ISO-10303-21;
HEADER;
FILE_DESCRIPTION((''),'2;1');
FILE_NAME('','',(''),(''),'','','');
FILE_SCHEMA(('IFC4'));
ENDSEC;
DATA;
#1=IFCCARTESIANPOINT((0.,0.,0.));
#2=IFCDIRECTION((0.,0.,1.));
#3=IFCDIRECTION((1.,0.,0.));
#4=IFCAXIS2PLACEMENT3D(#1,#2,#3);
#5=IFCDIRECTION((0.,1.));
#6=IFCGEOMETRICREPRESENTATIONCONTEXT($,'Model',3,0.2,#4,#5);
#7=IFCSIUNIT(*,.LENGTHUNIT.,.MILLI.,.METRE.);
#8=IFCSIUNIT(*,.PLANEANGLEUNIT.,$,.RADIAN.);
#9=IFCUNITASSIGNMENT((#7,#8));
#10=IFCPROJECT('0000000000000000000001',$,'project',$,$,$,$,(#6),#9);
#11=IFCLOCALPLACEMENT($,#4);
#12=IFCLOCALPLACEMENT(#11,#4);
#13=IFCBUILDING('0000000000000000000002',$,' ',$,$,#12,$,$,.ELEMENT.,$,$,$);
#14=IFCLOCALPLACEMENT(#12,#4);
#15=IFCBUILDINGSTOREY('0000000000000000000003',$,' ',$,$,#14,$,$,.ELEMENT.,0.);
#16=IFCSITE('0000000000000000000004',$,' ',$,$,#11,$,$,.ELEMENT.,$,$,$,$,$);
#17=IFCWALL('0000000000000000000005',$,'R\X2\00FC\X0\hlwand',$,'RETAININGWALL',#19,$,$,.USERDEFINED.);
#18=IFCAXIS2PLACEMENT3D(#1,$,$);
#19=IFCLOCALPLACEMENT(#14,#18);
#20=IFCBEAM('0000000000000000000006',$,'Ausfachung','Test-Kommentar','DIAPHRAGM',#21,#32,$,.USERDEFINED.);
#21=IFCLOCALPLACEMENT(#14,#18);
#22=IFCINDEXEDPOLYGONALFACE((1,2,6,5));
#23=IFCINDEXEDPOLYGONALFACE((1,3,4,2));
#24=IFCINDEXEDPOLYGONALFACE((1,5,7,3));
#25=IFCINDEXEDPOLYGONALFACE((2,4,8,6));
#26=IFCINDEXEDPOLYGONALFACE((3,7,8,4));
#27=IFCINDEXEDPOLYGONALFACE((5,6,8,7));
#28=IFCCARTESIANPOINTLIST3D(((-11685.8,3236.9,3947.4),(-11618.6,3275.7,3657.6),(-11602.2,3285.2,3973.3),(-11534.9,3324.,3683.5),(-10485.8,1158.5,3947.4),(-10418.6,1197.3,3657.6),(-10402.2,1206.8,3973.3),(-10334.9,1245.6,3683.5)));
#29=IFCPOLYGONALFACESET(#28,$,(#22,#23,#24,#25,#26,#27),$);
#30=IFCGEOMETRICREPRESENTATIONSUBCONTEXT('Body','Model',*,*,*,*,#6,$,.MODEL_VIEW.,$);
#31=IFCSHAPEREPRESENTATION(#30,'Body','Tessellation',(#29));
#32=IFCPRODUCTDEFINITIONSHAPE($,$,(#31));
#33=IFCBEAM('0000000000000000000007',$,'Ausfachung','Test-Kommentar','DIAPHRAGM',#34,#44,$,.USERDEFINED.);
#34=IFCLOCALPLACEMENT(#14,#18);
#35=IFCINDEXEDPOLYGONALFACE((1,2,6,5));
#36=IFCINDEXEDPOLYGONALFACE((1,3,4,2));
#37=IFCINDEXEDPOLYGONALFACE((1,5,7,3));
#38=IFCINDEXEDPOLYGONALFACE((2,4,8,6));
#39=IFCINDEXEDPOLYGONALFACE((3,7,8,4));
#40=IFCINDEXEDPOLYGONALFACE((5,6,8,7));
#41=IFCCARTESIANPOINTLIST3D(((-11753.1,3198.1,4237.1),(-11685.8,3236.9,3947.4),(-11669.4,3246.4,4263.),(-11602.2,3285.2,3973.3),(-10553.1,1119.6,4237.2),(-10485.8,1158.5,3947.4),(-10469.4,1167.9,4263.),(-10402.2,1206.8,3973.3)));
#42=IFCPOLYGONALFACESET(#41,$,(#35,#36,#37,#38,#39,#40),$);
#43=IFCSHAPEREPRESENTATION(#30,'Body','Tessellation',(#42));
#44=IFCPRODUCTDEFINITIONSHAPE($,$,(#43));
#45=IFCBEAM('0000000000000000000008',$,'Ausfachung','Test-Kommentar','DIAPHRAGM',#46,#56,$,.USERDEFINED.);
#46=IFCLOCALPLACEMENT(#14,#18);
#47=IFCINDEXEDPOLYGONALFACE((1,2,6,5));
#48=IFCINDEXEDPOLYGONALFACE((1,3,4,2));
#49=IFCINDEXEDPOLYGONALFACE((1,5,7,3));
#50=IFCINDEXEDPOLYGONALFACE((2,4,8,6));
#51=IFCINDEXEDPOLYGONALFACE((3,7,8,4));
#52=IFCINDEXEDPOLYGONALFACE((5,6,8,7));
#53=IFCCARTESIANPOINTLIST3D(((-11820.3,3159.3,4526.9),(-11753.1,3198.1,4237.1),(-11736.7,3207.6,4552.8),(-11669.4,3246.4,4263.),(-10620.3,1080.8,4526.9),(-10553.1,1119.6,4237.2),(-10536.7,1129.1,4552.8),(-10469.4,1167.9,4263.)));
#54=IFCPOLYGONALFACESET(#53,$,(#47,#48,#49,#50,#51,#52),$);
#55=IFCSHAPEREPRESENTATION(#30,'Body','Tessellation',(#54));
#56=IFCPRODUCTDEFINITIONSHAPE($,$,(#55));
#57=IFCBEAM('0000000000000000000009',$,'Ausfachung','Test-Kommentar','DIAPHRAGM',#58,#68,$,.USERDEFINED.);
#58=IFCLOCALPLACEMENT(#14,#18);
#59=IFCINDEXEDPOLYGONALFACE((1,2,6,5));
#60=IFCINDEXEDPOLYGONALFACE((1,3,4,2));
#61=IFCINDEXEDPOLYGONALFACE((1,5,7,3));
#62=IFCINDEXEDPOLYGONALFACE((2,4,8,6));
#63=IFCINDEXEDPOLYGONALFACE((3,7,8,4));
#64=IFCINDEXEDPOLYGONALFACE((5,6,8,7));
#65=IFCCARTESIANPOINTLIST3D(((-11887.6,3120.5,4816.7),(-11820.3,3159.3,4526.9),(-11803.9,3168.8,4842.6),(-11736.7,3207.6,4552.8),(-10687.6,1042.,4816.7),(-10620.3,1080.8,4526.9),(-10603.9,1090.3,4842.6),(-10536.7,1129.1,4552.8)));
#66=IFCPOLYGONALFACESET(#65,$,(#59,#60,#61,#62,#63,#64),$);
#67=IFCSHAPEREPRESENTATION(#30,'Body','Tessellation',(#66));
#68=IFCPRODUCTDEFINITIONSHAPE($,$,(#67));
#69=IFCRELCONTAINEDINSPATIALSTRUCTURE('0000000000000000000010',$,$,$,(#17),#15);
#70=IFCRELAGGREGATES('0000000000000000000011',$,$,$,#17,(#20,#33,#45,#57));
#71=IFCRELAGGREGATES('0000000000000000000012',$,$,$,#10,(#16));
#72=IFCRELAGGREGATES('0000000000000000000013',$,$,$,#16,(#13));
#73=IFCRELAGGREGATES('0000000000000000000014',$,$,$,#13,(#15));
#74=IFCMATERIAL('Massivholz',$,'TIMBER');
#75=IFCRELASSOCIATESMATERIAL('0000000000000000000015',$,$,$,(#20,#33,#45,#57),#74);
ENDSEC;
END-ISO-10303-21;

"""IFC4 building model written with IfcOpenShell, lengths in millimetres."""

from ifc_helpers import new_model, si_unit, direction, frame, origin_with_axes, place, context, subcontext, project, spatial, line, indexed_curve, outline, extrude, material, element, aggregate, save


model = new_model("IFC4")

# Units and contexts
model_context = context("Model", 3, precision=0.2, world=origin_with_axes(), true_north=direction((0.0, 1.0)))
body_context = subcontext(model_context, "Body", "Model", "MODEL_VIEW")
ifc_project = project(units=[si_unit("LENGTHUNIT", "METRE", prefix="MILLI"), si_unit("PLANEANGLEUNIT", "RADIAN")], contexts=[model_context])

# Site, building, storey
site_placement = place(None, origin_with_axes())
site = spatial("IfcSite", under=ifc_project, at=site_placement, Name=" ", CompositionType="ELEMENT")
building_placement = place(site_placement, origin_with_axes())
building = spatial("IfcBuilding", under=site, at=building_placement, Name=" ", CompositionType="ELEMENT")
storey_placement = place(building_placement, origin_with_axes())
storey = spatial("IfcBuildingStorey", under=building, at=storey_placement, Name=" ", CompositionType="ELEMENT", Elevation=0.0)

# Shared definitions
ifc_material_1 = material(Name="Massivholz", Category="TIMBER")

# Wall, beams
wall_1_placement = place(storey_placement, frame((-9848.6, 1445.5, 1545.5), z_axis=(-0.836516, -0.482964, -0.258819), x_axis=(0.499999, -0.866026, 0.000005)))
wall_1 = element("IfcWall", 1, at=wall_1_placement, inside=storey, Name="Rühlwand", ObjectType="RETAININGWALL", PredefinedType="USERDEFINED")
beam_1_placement = place(wall_1_placement, frame((-2470.0, 2350.0, 0.0), z_axis=(0.0, 0.0, -1.0), x_axis=(1.0, 0.0, 0.0)))
beam_1 = element("IfcBeam", 2, at=beam_1_placement, material=ifc_material_1, Name="Ausfachung", Description="Test-Kommentar", ObjectType="DIAPHRAGM", PredefinedType="USERDEFINED", context=body_context, shape_type="SolidModel", body=[
    extrude(outline(indexed_curve([(-50.0, -150.0), (50.0, -150.0), (50.0, 150.0), (-50.0, 150.0)], segments=[line(1, 2, 3, 4, 1)])), frame((0.0, 0.0, 0.0), z_axis=(-1.0, 0.0, 0.0), x_axis=(0.0, 0.0, 1.0)), (0.0, 0.0, -1.0), 2400.0),
])
beam_2_placement = place(wall_1_placement, frame((-2470.0, 2650.0, 0.0), z_axis=(0.0, 0.0, -1.0), x_axis=(1.0, 0.0, 0.0)))
beam_2 = element("IfcBeam", 3, at=beam_2_placement, material=ifc_material_1, Name="Ausfachung", Description="Test-Kommentar", ObjectType="DIAPHRAGM", PredefinedType="USERDEFINED", context=body_context, shape_type="SolidModel", body=[
    extrude(outline(indexed_curve([(-50.0, -150.0), (50.0, -150.0), (50.0, 150.0), (-50.0, 150.0)], segments=[line(1, 2, 3, 4, 1)])), frame((0.0, 0.0, 0.0), z_axis=(-1.0, 0.0, 0.0), x_axis=(0.0, 0.0, 1.0)), (0.0, 0.0, -1.0), 2400.0),
])
beam_3_placement = place(wall_1_placement, frame((-2470.0, 2950.0, 0.0), z_axis=(0.0, 0.0, -1.0), x_axis=(1.0, 0.0, 0.0)))
beam_3 = element("IfcBeam", 4, at=beam_3_placement, material=ifc_material_1, Name="Ausfachung", Description="Test-Kommentar", ObjectType="DIAPHRAGM", PredefinedType="USERDEFINED", context=body_context, shape_type="SolidModel", body=[
    extrude(outline(indexed_curve([(-50.0, -150.0), (50.0, -150.0), (50.0, 150.0), (-50.0, 150.0)], segments=[line(1, 2, 3, 4, 1)])), frame((0.0, 0.0, 0.0), z_axis=(-1.0, 0.0, 0.0), x_axis=(0.0, 0.0, 1.0)), (0.0, 0.0, -1.0), 2400.0),
])
beam_4_placement = place(wall_1_placement, frame((-2470.0, 3250.0, 0.0), z_axis=(0.0, 0.0, -1.0), x_axis=(1.0, 0.0, 0.0)))
beam_4 = element("IfcBeam", 5, at=beam_4_placement, material=ifc_material_1, Name="Ausfachung", Description="Test-Kommentar", ObjectType="DIAPHRAGM", PredefinedType="USERDEFINED", context=body_context, shape_type="SolidModel", body=[
    extrude(outline(indexed_curve([(-50.0, -150.0), (50.0, -150.0), (50.0, 150.0), (-50.0, 150.0)], segments=[line(1, 2, 3, 4, 1)])), frame((0.0, 0.0, 0.0), z_axis=(-1.0, 0.0, 0.0), x_axis=(0.0, 0.0, 1.0)), (0.0, 0.0, -1.0), 2400.0),
])
aggregate(wall_1, [beam_1, beam_2, beam_3, beam_4])

save(model, "model.ifc")
